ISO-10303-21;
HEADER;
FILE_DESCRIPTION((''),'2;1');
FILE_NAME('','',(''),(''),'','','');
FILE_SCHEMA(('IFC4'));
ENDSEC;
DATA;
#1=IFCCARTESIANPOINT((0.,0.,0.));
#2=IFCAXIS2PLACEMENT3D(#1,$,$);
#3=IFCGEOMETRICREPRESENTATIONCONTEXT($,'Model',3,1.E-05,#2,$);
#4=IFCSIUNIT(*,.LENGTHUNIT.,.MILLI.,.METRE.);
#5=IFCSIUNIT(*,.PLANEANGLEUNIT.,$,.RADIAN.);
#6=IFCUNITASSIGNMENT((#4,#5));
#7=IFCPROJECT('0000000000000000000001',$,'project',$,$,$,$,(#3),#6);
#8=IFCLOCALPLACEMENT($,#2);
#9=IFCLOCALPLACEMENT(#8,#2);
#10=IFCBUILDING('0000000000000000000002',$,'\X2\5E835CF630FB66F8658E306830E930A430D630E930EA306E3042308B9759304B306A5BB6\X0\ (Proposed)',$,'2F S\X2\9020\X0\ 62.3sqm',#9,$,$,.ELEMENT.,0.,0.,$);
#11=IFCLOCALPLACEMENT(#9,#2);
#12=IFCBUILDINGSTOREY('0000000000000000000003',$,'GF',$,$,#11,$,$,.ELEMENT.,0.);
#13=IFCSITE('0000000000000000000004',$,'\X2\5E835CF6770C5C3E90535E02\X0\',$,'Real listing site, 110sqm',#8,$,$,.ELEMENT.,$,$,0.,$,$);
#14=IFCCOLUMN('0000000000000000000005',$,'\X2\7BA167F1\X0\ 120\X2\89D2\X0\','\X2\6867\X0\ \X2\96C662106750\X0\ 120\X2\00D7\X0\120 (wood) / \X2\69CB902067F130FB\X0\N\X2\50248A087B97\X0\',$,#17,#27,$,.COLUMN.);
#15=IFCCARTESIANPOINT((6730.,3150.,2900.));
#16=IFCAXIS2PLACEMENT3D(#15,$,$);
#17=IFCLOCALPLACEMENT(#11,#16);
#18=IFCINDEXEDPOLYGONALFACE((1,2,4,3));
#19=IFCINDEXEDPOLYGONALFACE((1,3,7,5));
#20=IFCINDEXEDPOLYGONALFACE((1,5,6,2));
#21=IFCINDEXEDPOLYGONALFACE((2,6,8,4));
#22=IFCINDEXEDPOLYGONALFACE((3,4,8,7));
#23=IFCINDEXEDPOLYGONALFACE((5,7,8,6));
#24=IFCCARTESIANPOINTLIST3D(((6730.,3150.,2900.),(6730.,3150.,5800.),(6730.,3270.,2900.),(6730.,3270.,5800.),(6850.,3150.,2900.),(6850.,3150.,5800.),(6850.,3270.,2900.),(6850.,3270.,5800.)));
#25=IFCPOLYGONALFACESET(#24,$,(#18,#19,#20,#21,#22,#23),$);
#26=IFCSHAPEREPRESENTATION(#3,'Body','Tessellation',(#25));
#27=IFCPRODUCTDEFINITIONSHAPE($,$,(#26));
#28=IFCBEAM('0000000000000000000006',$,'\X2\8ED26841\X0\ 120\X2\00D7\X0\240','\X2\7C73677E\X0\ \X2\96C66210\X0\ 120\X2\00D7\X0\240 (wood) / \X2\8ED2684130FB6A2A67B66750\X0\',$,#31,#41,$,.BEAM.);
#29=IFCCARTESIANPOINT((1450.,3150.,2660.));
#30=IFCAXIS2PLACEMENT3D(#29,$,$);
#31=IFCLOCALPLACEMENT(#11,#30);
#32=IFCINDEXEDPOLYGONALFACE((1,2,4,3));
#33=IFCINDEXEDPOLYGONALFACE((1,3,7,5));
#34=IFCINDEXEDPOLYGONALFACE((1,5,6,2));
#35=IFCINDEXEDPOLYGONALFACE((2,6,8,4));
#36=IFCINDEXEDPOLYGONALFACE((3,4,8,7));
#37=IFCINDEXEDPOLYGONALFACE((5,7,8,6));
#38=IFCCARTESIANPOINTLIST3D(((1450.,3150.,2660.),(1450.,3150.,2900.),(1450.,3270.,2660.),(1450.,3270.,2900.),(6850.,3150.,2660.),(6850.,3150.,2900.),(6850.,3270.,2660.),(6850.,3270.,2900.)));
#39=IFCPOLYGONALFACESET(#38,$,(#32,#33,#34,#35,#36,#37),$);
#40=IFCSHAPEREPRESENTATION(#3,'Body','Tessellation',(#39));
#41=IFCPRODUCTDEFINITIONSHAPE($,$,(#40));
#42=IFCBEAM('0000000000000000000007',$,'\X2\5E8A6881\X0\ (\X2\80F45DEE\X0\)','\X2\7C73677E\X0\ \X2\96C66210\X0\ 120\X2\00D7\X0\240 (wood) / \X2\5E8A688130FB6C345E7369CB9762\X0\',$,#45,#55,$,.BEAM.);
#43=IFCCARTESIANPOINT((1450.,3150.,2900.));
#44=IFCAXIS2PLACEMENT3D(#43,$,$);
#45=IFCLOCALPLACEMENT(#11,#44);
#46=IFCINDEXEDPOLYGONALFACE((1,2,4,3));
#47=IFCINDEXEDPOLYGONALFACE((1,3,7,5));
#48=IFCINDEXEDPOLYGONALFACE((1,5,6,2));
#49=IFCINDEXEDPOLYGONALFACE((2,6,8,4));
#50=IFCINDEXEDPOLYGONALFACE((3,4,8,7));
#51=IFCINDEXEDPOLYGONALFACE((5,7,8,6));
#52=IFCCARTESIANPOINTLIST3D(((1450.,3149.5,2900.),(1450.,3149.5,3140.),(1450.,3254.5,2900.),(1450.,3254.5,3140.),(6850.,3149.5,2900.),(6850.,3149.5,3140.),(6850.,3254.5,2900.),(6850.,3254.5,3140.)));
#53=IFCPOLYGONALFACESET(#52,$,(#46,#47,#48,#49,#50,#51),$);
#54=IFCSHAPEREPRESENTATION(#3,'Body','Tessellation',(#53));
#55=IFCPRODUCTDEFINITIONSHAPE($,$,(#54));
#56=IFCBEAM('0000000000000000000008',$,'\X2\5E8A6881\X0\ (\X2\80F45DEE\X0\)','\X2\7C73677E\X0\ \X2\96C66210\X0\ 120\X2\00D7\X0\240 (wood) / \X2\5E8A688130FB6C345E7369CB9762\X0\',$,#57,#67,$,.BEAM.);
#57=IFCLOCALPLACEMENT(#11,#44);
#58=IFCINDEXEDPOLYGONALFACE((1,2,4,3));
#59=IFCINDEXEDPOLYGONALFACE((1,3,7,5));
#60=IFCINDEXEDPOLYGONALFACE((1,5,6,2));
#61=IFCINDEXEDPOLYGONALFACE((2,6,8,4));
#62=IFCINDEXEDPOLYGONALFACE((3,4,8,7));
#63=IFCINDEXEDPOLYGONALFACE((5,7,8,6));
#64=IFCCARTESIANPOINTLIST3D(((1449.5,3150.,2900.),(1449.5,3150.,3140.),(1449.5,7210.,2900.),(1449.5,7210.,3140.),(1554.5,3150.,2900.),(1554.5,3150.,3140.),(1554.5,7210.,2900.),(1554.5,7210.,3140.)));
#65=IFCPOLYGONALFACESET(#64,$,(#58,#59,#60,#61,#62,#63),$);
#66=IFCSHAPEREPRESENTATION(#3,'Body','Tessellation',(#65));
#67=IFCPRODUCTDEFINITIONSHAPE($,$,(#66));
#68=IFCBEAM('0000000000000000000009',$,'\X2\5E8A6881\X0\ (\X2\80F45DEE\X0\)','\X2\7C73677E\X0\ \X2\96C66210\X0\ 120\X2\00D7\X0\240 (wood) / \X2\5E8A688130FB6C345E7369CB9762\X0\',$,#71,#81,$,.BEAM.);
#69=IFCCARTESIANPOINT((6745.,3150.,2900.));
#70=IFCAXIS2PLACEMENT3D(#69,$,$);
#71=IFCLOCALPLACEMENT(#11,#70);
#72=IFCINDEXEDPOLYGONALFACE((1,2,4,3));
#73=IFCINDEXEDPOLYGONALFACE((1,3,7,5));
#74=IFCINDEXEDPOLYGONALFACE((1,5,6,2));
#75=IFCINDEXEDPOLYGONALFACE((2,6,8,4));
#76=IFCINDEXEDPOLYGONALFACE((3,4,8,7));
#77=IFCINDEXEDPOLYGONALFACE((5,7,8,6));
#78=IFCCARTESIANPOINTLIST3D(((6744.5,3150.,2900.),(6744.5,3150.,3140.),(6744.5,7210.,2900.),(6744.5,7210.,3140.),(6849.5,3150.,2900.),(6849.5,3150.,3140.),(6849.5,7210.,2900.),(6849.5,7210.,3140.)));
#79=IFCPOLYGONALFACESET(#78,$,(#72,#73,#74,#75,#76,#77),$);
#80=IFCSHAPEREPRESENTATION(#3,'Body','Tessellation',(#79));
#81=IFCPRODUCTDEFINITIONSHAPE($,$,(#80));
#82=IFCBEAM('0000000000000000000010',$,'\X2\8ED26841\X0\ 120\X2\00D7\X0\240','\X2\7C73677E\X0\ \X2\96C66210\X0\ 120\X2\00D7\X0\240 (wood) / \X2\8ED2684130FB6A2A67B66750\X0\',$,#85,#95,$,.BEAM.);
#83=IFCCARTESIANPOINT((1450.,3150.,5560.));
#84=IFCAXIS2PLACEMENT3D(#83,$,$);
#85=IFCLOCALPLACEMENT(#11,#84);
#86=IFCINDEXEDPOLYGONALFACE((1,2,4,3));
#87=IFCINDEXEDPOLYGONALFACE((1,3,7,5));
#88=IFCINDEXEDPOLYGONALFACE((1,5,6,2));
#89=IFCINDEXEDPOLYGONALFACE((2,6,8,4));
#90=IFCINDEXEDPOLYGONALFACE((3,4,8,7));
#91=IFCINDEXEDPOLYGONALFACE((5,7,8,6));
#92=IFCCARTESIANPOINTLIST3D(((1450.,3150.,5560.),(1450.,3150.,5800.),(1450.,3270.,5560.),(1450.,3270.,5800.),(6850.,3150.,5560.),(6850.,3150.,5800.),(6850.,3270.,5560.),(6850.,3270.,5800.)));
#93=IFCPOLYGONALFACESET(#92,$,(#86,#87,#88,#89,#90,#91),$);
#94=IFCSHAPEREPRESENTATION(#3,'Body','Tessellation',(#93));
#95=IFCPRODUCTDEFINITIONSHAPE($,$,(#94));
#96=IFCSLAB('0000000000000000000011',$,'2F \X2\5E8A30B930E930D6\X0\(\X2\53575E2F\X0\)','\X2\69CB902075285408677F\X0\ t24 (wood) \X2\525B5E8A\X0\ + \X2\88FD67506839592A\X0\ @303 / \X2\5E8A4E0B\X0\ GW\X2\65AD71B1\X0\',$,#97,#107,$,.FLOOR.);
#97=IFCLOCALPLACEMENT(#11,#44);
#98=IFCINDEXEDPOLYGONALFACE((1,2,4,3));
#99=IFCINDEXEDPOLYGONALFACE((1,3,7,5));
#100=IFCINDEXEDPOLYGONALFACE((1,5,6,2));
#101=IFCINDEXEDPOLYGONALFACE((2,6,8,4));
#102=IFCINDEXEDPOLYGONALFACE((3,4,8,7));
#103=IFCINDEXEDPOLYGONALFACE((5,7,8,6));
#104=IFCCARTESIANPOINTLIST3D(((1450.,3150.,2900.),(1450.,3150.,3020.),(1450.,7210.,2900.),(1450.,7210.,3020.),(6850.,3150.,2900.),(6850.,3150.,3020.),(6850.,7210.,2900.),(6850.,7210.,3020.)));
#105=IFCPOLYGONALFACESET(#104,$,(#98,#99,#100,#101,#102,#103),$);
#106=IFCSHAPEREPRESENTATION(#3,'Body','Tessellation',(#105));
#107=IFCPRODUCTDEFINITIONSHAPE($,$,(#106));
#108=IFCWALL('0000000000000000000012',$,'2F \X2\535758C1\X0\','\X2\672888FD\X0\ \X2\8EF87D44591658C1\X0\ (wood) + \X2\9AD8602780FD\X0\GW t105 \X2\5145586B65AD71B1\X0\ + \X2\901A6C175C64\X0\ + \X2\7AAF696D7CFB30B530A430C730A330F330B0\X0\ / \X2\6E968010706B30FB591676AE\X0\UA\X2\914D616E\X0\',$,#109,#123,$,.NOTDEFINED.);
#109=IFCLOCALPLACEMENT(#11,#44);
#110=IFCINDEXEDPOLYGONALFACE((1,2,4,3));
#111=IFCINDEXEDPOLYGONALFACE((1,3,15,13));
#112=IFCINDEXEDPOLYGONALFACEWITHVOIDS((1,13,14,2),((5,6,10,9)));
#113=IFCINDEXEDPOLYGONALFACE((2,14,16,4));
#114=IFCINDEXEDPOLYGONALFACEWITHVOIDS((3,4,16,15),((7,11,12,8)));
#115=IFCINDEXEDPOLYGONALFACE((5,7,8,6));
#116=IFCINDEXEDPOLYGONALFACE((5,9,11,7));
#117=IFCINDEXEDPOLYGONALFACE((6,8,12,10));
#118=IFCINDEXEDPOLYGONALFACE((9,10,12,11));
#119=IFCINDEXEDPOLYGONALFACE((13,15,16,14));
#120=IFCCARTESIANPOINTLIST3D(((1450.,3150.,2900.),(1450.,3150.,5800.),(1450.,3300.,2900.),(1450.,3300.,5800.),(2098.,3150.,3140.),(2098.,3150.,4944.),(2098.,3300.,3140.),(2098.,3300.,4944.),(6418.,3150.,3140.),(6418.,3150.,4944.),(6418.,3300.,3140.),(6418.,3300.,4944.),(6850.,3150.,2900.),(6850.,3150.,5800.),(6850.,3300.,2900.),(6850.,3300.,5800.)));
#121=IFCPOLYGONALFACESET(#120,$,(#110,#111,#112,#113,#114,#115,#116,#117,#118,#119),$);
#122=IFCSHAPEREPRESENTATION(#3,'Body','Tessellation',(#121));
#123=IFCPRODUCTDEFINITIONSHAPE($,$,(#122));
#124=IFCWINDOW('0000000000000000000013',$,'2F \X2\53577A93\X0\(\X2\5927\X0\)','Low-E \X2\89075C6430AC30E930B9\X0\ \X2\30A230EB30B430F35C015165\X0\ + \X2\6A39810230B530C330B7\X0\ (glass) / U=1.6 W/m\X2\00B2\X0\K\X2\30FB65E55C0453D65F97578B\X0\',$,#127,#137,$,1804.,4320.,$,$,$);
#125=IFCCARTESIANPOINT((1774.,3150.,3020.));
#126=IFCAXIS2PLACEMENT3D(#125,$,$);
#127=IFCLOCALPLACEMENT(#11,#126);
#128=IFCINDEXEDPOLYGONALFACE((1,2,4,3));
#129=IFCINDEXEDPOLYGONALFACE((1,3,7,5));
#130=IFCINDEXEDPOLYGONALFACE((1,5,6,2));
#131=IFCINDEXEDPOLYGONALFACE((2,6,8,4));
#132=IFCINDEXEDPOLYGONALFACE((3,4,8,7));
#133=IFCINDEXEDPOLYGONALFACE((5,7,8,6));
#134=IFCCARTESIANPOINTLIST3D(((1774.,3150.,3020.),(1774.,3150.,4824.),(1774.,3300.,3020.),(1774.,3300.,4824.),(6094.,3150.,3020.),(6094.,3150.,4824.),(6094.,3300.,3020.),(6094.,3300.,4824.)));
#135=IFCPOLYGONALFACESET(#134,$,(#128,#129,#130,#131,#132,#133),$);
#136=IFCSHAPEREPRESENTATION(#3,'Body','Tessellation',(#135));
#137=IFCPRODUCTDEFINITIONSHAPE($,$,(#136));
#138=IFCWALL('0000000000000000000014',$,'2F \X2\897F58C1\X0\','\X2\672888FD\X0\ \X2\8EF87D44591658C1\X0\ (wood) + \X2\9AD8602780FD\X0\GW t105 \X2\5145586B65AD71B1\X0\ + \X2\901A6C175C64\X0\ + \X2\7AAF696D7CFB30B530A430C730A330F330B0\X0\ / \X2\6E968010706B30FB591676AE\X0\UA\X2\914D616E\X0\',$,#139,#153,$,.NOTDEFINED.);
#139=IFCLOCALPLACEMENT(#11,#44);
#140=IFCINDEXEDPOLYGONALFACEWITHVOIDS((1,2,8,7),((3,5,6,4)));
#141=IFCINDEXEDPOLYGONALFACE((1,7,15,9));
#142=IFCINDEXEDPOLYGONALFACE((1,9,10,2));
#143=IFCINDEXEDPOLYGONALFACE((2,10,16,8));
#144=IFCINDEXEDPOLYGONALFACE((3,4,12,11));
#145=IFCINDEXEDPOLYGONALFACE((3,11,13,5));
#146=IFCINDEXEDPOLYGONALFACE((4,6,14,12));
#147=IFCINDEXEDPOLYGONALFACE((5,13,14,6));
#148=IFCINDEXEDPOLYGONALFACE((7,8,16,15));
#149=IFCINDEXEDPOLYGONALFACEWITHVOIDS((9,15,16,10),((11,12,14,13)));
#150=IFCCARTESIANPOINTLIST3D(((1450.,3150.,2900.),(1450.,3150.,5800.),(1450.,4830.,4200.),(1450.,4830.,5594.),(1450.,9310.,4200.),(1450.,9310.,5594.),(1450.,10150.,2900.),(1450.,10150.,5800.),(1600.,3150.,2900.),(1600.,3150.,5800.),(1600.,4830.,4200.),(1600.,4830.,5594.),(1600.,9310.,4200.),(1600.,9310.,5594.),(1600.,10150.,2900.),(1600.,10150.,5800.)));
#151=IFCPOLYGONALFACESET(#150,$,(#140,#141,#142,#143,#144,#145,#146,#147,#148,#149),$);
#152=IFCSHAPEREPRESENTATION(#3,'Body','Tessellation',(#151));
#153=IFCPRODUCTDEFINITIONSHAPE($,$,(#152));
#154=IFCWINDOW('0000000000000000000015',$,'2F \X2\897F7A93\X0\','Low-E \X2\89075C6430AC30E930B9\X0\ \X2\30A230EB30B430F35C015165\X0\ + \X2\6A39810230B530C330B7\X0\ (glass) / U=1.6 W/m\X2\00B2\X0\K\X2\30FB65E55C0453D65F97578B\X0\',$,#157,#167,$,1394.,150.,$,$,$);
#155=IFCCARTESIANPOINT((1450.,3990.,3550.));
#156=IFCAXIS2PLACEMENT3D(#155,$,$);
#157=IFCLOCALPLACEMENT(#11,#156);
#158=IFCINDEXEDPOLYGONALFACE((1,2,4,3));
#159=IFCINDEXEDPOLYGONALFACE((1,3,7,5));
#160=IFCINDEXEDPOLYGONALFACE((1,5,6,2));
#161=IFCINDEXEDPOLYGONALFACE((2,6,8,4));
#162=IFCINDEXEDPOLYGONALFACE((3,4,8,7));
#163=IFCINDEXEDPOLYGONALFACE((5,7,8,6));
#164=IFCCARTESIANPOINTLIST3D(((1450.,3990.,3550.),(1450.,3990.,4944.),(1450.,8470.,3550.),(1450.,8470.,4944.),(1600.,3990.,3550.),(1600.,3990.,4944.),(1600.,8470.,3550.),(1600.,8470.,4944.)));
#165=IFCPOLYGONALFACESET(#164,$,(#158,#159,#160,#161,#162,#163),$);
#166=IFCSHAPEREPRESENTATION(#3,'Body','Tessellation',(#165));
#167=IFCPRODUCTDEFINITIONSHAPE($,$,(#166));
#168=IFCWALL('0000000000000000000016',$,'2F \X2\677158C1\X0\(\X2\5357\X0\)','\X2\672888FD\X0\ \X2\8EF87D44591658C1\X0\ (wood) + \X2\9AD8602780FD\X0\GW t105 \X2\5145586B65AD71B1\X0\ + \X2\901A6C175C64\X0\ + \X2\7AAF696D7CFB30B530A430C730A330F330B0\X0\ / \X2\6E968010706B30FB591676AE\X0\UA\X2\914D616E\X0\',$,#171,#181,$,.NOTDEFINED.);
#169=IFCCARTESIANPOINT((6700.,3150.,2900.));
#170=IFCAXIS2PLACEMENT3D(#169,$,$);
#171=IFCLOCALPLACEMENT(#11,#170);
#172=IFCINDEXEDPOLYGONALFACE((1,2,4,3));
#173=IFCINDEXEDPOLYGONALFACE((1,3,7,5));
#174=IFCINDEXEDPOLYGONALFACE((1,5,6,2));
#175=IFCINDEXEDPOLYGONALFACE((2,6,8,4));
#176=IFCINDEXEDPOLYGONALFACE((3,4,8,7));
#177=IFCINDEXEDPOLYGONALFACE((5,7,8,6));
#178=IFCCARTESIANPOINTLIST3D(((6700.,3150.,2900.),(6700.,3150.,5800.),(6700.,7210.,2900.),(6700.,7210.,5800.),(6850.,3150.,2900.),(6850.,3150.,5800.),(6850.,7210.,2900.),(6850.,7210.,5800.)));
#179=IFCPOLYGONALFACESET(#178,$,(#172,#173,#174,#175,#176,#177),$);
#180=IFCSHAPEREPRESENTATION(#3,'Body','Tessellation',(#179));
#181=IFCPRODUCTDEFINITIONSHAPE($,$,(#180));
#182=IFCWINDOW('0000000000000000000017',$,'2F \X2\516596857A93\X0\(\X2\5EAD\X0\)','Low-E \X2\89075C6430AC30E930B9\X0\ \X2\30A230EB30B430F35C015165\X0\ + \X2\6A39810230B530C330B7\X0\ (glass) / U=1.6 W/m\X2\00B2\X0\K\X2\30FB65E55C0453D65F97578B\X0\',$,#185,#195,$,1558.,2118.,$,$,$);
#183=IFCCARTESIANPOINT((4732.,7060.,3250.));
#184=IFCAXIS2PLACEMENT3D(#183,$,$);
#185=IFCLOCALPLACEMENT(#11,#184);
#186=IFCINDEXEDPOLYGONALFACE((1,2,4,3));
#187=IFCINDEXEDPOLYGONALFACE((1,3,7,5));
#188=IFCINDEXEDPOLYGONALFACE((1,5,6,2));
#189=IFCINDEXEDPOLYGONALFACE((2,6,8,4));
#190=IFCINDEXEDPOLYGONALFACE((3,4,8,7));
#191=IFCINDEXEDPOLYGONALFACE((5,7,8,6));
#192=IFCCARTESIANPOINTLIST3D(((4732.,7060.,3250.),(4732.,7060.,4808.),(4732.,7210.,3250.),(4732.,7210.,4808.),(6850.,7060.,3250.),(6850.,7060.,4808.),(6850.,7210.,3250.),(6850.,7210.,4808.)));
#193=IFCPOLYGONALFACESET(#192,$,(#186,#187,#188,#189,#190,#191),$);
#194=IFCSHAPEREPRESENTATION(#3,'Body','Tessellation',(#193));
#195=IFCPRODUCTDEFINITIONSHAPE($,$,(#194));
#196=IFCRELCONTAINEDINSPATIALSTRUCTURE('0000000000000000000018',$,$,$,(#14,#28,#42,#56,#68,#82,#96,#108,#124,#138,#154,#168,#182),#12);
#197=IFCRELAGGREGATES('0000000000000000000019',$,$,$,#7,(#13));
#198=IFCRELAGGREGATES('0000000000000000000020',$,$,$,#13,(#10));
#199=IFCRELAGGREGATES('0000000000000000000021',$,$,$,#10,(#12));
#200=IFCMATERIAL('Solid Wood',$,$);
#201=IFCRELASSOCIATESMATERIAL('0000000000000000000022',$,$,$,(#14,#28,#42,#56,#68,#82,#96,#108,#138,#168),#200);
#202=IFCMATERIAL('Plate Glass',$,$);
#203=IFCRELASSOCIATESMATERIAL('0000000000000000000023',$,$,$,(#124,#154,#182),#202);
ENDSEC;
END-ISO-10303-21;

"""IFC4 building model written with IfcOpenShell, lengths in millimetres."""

from ifc_helpers import new_model, si_unit, frame, frame_2d, origin, place, context, project, spatial, rectangle, extrude, material, element, fill, save


model = new_model("IFC4")

# Units and contexts
model_context = context("Model", 3, precision=1e-05, world=origin())
ifc_project = project(units=[si_unit("LENGTHUNIT", "METRE", prefix="MILLI"), si_unit("PLANEANGLEUNIT", "RADIAN")], contexts=[model_context])

# Site, building, storey
site_placement = place(None, origin())
site = spatial("IfcSite", under=ifc_project, at=site_placement, Name="広島県尾道市", ObjectType="Real listing site, 110sqm", CompositionType="ELEMENT", RefElevation=0.0)
building_placement = place(site_placement, origin())
building = spatial("IfcBuilding", under=site, at=building_placement, Name="広島・書斎とライブラリのある静かな家 (Proposed)", ObjectType="2F S造 62.3sqm", CompositionType="ELEMENT", ElevationOfRefHeight=0.0, ElevationOfTerrain=0.0)
storey_placement = place(building_placement, origin())
storey = spatial("IfcBuildingStorey", under=building, at=storey_placement, Name="GF", CompositionType="ELEMENT", Elevation=0.0)

# Column
ifc_material_1 = material(Name="Solid Wood")
column_1_placement = place(storey_placement, frame((6730.0, 3150.0, 2900.0)))
element("IfcColumn", 1, at=column_1_placement, inside=storey, material=ifc_material_1, Name="管柱 120角", Description="桧 集成材 120×120 (wood) / 構造柱・N値計算", PredefinedType="COLUMN", context=model_context, shape_type="SweptSolid", body=[
    extrude(rectangle(XDim=120.0, YDim=120.0, at=frame_2d((60.0, 60.0))), frame((6730.0, 3150.0, 2900.0)), (0.0, 0.0, 1.0), 2900.0),
])

# Beams
beam_1_placement = place(storey_placement, frame((1450.0, 3150.0, 2660.0)))
element("IfcBeam", 2, at=beam_1_placement, inside=storey, material=ifc_material_1, Name="軒桁 120×240", Description="米松 集成 120×240 (wood) / 軒桁・横架材", PredefinedType="BEAM", context=model_context, shape_type="SweptSolid", body=[
    extrude(rectangle(XDim=5400.0, YDim=120.0, at=frame_2d((2700.0, 60.0))), frame((1450.0, 3150.0, 2660.0)), (0.0, 0.0, 1.0), 240.0),
])
beam_2_placement = place(storey_placement, frame((1450.0, 3150.0, 2900.0)))
element("IfcBeam", 3, at=beam_2_placement, inside=storey, material=ifc_material_1, Name="床梁 (胴差)", Description="米松 集成 120×240 (wood) / 床梁・水平構面", PredefinedType="BEAM", context=model_context, shape_type="SweptSolid", body=[
    extrude(rectangle(XDim=5400.0, YDim=105.0, at=frame_2d((2700.0, 52.0))), frame((1450.0, 3150.0, 2900.0)), (0.0, 0.0, 1.0), 240.0),
])
beam_3_placement = place(storey_placement, frame((1450.0, 3150.0, 2900.0)))
element("IfcBeam", 4, at=beam_3_placement, inside=storey, material=ifc_material_1, Name="床梁 (胴差)", Description="米松 集成 120×240 (wood) / 床梁・水平構面", PredefinedType="BEAM", context=model_context, shape_type="SweptSolid", body=[
    extrude(rectangle(XDim=105.0, YDim=4060.0, at=frame_2d((52.0, 2030.0))), frame((1450.0, 3150.0, 2900.0)), (0.0, 0.0, 1.0), 240.0),
])
beam_4_placement = place(storey_placement, frame((6745.0, 3150.0, 2900.0)))
element("IfcBeam", 5, at=beam_4_placement, inside=storey, material=ifc_material_1, Name="床梁 (胴差)", Description="米松 集成 120×240 (wood) / 床梁・水平構面", PredefinedType="BEAM", context=model_context, shape_type="SweptSolid", body=[
    extrude(rectangle(XDim=105.0, YDim=4060.0, at=frame_2d((52.0, 2030.0))), frame((6745.0, 3150.0, 2900.0)), (0.0, 0.0, 1.0), 240.0),
])
beam_5_placement = place(storey_placement, frame((1450.0, 3150.0, 5560.0)))
element("IfcBeam", 6, at=beam_5_placement, inside=storey, material=ifc_material_1, Name="軒桁 120×240", Description="米松 集成 120×240 (wood) / 軒桁・横架材", PredefinedType="BEAM", context=model_context, shape_type="SweptSolid", body=[
    extrude(rectangle(XDim=5400.0, YDim=120.0, at=frame_2d((2700.0, 60.0))), frame((1450.0, 3150.0, 5560.0)), (0.0, 0.0, 1.0), 240.0),
])

# Slab
slab_placement = place(storey_placement, frame((1450.0, 3150.0, 2900.0)))
element("IfcSlab", 7, at=slab_placement, inside=storey, material=ifc_material_1, Name="2F 床スラブ(南帯)", Description="構造用合板 t24 (wood) 剛床 + 製材根太 @303 / 床下 GW断熱", PredefinedType="FLOOR", context=model_context, shape_type="SweptSolid", body=[
    extrude(rectangle(XDim=5400.0, YDim=4060.0, at=frame_2d((2700.0, 2030.0))), frame((1450.0, 3150.0, 2900.0)), (0.0, 0.0, 1.0), 120.0),
])

# Walls, openings, windows
wall_1_placement = place(storey_placement, frame((1450.0, 3150.0, 2900.0)))
wall_1 = element("IfcWall", 8, at=wall_1_placement, inside=storey, material=ifc_material_1, Name="2F 南壁", Description="木製 軸組外壁 (wood) + 高性能GW t105 充填断熱 + 通気層 + 窯業系サイディング / 準耐火・外皮UA配慮", PredefinedType="NOTDEFINED", context=model_context, shape_type="SweptSolid", body=[
    extrude(rectangle(XDim=5400.0, YDim=150.0, at=frame_2d((2700.0, 75.0))), frame((1450.0, 3150.0, 2900.0)), (0.0, 0.0, 1.0), 2900.0),
])
opening_1_placement = place(storey_placement, frame((1774.0, 3150.0, 3020.0)))
opening_1 = element("IfcOpeningElement", 9, at=opening_1_placement, cuts=wall_1, PredefinedType="NOTDEFINED", context=model_context, shape_type="SweptSolid", body=[
    extrude(rectangle(XDim=4320.0, YDim=150.0, at=frame_2d((2160.0, 75.0))), frame((1774.0, 3150.0, 3020.0)), (0.0, 0.0, 1.0), 1804.0),
])
ifc_material_2 = material(Name="Plate Glass")
window_1_placement = place(storey_placement, frame((1774.0, 3150.0, 3020.0)))
window_1 = element("IfcWindow", 10, at=window_1_placement, inside=storey, material=ifc_material_2, Name="2F 南窓(大)", Description="Low-E 複層ガラス アルゴン封入 + 樹脂サッシ (glass) / U=1.6 W/m²K・日射取得型", OverallHeight=1804.0, OverallWidth=4320.0, context=model_context, shape_type="SweptSolid", body=[
    extrude(rectangle(XDim=4320.0, YDim=150.0, at=frame_2d((2160.0, 75.0))), frame((1774.0, 3150.0, 3020.0)), (0.0, 0.0, 1.0), 1804.0),
])
fill(opening_1, window_1)
wall_2_placement = place(storey_placement, frame((1450.0, 3150.0, 2900.0)))
wall_2 = element("IfcWall", 11, at=wall_2_placement, inside=storey, material=ifc_material_1, Name="2F 西壁", Description="木製 軸組外壁 (wood) + 高性能GW t105 充填断熱 + 通気層 + 窯業系サイディング / 準耐火・外皮UA配慮", PredefinedType="NOTDEFINED", context=model_context, shape_type="SweptSolid", body=[
    extrude(rectangle(XDim=150.0, YDim=7000.0, at=frame_2d((75.0, 3500.0))), frame((1450.0, 3150.0, 2900.0)), (0.0, 0.0, 1.0), 2900.0),
])
opening_2_placement = place(storey_placement, frame((1450.0, 3990.0, 3550.0)))
opening_2 = element("IfcOpeningElement", 12, at=opening_2_placement, cuts=wall_2, PredefinedType="NOTDEFINED", context=model_context, shape_type="SweptSolid", body=[
    extrude(rectangle(XDim=150.0, YDim=4480.0, at=frame_2d((75.0, 2240.0))), frame((1450.0, 3990.0, 3550.0)), (0.0, 0.0, 1.0), 1394.0),
])
window_2_placement = place(storey_placement, frame((1450.0, 3990.0, 3550.0)))
window_2 = element("IfcWindow", 13, at=window_2_placement, inside=storey, material=ifc_material_2, Name="2F 西窓", Description="Low-E 複層ガラス アルゴン封入 + 樹脂サッシ (glass) / U=1.6 W/m²K・日射取得型", OverallHeight=1394.0, OverallWidth=150.0, context=model_context, shape_type="SweptSolid", body=[
    extrude(rectangle(XDim=150.0, YDim=4480.0, at=frame_2d((75.0, 2240.0))), frame((1450.0, 3990.0, 3550.0)), (0.0, 0.0, 1.0), 1394.0),
])
fill(opening_2, window_2)
wall_3_placement = place(storey_placement, frame((6700.0, 3150.0, 2900.0)))
wall_3 = element("IfcWall", 14, at=wall_3_placement, inside=storey, material=ifc_material_1, Name="2F 東壁(南)", Description="木製 軸組外壁 (wood) + 高性能GW t105 充填断熱 + 通気層 + 窯業系サイディング / 準耐火・外皮UA配慮", PredefinedType="NOTDEFINED", context=model_context, shape_type="SweptSolid", body=[
    extrude(rectangle(XDim=150.0, YDim=4060.0, at=frame_2d((75.0, 2030.0))), frame((6700.0, 3150.0, 2900.0)), (0.0, 0.0, 1.0), 2900.0),
])
opening_3_placement = place(storey_placement, frame((4732.0, 7060.0, 3250.0)))
opening_3 = element("IfcOpeningElement", 15, at=opening_3_placement, cuts=wall_3, PredefinedType="NOTDEFINED", context=model_context, shape_type="SweptSolid", body=[
    extrude(rectangle(XDim=2118.0, YDim=150.0, at=frame_2d((1059.0, 75.0))), frame((4732.0, 7060.0, 3250.0)), (0.0, 0.0, 1.0), 1558.0),
])
window_3_placement = place(storey_placement, frame((4732.0, 7060.0, 3250.0)))
window_3 = element("IfcWindow", 16, at=window_3_placement, inside=storey, material=ifc_material_2, Name="2F 入隅窓(庭)", Description="Low-E 複層ガラス アルゴン封入 + 樹脂サッシ (glass) / U=1.6 W/m²K・日射取得型", OverallHeight=1558.0, OverallWidth=2118.0, context=model_context, shape_type="SweptSolid", body=[
    extrude(rectangle(XDim=2118.0, YDim=150.0, at=frame_2d((1059.0, 75.0))), frame((4732.0, 7060.0, 3250.0)), (0.0, 0.0, 1.0), 1558.0),
])
fill(opening_3, window_3)

save(model, "model.ifc")
